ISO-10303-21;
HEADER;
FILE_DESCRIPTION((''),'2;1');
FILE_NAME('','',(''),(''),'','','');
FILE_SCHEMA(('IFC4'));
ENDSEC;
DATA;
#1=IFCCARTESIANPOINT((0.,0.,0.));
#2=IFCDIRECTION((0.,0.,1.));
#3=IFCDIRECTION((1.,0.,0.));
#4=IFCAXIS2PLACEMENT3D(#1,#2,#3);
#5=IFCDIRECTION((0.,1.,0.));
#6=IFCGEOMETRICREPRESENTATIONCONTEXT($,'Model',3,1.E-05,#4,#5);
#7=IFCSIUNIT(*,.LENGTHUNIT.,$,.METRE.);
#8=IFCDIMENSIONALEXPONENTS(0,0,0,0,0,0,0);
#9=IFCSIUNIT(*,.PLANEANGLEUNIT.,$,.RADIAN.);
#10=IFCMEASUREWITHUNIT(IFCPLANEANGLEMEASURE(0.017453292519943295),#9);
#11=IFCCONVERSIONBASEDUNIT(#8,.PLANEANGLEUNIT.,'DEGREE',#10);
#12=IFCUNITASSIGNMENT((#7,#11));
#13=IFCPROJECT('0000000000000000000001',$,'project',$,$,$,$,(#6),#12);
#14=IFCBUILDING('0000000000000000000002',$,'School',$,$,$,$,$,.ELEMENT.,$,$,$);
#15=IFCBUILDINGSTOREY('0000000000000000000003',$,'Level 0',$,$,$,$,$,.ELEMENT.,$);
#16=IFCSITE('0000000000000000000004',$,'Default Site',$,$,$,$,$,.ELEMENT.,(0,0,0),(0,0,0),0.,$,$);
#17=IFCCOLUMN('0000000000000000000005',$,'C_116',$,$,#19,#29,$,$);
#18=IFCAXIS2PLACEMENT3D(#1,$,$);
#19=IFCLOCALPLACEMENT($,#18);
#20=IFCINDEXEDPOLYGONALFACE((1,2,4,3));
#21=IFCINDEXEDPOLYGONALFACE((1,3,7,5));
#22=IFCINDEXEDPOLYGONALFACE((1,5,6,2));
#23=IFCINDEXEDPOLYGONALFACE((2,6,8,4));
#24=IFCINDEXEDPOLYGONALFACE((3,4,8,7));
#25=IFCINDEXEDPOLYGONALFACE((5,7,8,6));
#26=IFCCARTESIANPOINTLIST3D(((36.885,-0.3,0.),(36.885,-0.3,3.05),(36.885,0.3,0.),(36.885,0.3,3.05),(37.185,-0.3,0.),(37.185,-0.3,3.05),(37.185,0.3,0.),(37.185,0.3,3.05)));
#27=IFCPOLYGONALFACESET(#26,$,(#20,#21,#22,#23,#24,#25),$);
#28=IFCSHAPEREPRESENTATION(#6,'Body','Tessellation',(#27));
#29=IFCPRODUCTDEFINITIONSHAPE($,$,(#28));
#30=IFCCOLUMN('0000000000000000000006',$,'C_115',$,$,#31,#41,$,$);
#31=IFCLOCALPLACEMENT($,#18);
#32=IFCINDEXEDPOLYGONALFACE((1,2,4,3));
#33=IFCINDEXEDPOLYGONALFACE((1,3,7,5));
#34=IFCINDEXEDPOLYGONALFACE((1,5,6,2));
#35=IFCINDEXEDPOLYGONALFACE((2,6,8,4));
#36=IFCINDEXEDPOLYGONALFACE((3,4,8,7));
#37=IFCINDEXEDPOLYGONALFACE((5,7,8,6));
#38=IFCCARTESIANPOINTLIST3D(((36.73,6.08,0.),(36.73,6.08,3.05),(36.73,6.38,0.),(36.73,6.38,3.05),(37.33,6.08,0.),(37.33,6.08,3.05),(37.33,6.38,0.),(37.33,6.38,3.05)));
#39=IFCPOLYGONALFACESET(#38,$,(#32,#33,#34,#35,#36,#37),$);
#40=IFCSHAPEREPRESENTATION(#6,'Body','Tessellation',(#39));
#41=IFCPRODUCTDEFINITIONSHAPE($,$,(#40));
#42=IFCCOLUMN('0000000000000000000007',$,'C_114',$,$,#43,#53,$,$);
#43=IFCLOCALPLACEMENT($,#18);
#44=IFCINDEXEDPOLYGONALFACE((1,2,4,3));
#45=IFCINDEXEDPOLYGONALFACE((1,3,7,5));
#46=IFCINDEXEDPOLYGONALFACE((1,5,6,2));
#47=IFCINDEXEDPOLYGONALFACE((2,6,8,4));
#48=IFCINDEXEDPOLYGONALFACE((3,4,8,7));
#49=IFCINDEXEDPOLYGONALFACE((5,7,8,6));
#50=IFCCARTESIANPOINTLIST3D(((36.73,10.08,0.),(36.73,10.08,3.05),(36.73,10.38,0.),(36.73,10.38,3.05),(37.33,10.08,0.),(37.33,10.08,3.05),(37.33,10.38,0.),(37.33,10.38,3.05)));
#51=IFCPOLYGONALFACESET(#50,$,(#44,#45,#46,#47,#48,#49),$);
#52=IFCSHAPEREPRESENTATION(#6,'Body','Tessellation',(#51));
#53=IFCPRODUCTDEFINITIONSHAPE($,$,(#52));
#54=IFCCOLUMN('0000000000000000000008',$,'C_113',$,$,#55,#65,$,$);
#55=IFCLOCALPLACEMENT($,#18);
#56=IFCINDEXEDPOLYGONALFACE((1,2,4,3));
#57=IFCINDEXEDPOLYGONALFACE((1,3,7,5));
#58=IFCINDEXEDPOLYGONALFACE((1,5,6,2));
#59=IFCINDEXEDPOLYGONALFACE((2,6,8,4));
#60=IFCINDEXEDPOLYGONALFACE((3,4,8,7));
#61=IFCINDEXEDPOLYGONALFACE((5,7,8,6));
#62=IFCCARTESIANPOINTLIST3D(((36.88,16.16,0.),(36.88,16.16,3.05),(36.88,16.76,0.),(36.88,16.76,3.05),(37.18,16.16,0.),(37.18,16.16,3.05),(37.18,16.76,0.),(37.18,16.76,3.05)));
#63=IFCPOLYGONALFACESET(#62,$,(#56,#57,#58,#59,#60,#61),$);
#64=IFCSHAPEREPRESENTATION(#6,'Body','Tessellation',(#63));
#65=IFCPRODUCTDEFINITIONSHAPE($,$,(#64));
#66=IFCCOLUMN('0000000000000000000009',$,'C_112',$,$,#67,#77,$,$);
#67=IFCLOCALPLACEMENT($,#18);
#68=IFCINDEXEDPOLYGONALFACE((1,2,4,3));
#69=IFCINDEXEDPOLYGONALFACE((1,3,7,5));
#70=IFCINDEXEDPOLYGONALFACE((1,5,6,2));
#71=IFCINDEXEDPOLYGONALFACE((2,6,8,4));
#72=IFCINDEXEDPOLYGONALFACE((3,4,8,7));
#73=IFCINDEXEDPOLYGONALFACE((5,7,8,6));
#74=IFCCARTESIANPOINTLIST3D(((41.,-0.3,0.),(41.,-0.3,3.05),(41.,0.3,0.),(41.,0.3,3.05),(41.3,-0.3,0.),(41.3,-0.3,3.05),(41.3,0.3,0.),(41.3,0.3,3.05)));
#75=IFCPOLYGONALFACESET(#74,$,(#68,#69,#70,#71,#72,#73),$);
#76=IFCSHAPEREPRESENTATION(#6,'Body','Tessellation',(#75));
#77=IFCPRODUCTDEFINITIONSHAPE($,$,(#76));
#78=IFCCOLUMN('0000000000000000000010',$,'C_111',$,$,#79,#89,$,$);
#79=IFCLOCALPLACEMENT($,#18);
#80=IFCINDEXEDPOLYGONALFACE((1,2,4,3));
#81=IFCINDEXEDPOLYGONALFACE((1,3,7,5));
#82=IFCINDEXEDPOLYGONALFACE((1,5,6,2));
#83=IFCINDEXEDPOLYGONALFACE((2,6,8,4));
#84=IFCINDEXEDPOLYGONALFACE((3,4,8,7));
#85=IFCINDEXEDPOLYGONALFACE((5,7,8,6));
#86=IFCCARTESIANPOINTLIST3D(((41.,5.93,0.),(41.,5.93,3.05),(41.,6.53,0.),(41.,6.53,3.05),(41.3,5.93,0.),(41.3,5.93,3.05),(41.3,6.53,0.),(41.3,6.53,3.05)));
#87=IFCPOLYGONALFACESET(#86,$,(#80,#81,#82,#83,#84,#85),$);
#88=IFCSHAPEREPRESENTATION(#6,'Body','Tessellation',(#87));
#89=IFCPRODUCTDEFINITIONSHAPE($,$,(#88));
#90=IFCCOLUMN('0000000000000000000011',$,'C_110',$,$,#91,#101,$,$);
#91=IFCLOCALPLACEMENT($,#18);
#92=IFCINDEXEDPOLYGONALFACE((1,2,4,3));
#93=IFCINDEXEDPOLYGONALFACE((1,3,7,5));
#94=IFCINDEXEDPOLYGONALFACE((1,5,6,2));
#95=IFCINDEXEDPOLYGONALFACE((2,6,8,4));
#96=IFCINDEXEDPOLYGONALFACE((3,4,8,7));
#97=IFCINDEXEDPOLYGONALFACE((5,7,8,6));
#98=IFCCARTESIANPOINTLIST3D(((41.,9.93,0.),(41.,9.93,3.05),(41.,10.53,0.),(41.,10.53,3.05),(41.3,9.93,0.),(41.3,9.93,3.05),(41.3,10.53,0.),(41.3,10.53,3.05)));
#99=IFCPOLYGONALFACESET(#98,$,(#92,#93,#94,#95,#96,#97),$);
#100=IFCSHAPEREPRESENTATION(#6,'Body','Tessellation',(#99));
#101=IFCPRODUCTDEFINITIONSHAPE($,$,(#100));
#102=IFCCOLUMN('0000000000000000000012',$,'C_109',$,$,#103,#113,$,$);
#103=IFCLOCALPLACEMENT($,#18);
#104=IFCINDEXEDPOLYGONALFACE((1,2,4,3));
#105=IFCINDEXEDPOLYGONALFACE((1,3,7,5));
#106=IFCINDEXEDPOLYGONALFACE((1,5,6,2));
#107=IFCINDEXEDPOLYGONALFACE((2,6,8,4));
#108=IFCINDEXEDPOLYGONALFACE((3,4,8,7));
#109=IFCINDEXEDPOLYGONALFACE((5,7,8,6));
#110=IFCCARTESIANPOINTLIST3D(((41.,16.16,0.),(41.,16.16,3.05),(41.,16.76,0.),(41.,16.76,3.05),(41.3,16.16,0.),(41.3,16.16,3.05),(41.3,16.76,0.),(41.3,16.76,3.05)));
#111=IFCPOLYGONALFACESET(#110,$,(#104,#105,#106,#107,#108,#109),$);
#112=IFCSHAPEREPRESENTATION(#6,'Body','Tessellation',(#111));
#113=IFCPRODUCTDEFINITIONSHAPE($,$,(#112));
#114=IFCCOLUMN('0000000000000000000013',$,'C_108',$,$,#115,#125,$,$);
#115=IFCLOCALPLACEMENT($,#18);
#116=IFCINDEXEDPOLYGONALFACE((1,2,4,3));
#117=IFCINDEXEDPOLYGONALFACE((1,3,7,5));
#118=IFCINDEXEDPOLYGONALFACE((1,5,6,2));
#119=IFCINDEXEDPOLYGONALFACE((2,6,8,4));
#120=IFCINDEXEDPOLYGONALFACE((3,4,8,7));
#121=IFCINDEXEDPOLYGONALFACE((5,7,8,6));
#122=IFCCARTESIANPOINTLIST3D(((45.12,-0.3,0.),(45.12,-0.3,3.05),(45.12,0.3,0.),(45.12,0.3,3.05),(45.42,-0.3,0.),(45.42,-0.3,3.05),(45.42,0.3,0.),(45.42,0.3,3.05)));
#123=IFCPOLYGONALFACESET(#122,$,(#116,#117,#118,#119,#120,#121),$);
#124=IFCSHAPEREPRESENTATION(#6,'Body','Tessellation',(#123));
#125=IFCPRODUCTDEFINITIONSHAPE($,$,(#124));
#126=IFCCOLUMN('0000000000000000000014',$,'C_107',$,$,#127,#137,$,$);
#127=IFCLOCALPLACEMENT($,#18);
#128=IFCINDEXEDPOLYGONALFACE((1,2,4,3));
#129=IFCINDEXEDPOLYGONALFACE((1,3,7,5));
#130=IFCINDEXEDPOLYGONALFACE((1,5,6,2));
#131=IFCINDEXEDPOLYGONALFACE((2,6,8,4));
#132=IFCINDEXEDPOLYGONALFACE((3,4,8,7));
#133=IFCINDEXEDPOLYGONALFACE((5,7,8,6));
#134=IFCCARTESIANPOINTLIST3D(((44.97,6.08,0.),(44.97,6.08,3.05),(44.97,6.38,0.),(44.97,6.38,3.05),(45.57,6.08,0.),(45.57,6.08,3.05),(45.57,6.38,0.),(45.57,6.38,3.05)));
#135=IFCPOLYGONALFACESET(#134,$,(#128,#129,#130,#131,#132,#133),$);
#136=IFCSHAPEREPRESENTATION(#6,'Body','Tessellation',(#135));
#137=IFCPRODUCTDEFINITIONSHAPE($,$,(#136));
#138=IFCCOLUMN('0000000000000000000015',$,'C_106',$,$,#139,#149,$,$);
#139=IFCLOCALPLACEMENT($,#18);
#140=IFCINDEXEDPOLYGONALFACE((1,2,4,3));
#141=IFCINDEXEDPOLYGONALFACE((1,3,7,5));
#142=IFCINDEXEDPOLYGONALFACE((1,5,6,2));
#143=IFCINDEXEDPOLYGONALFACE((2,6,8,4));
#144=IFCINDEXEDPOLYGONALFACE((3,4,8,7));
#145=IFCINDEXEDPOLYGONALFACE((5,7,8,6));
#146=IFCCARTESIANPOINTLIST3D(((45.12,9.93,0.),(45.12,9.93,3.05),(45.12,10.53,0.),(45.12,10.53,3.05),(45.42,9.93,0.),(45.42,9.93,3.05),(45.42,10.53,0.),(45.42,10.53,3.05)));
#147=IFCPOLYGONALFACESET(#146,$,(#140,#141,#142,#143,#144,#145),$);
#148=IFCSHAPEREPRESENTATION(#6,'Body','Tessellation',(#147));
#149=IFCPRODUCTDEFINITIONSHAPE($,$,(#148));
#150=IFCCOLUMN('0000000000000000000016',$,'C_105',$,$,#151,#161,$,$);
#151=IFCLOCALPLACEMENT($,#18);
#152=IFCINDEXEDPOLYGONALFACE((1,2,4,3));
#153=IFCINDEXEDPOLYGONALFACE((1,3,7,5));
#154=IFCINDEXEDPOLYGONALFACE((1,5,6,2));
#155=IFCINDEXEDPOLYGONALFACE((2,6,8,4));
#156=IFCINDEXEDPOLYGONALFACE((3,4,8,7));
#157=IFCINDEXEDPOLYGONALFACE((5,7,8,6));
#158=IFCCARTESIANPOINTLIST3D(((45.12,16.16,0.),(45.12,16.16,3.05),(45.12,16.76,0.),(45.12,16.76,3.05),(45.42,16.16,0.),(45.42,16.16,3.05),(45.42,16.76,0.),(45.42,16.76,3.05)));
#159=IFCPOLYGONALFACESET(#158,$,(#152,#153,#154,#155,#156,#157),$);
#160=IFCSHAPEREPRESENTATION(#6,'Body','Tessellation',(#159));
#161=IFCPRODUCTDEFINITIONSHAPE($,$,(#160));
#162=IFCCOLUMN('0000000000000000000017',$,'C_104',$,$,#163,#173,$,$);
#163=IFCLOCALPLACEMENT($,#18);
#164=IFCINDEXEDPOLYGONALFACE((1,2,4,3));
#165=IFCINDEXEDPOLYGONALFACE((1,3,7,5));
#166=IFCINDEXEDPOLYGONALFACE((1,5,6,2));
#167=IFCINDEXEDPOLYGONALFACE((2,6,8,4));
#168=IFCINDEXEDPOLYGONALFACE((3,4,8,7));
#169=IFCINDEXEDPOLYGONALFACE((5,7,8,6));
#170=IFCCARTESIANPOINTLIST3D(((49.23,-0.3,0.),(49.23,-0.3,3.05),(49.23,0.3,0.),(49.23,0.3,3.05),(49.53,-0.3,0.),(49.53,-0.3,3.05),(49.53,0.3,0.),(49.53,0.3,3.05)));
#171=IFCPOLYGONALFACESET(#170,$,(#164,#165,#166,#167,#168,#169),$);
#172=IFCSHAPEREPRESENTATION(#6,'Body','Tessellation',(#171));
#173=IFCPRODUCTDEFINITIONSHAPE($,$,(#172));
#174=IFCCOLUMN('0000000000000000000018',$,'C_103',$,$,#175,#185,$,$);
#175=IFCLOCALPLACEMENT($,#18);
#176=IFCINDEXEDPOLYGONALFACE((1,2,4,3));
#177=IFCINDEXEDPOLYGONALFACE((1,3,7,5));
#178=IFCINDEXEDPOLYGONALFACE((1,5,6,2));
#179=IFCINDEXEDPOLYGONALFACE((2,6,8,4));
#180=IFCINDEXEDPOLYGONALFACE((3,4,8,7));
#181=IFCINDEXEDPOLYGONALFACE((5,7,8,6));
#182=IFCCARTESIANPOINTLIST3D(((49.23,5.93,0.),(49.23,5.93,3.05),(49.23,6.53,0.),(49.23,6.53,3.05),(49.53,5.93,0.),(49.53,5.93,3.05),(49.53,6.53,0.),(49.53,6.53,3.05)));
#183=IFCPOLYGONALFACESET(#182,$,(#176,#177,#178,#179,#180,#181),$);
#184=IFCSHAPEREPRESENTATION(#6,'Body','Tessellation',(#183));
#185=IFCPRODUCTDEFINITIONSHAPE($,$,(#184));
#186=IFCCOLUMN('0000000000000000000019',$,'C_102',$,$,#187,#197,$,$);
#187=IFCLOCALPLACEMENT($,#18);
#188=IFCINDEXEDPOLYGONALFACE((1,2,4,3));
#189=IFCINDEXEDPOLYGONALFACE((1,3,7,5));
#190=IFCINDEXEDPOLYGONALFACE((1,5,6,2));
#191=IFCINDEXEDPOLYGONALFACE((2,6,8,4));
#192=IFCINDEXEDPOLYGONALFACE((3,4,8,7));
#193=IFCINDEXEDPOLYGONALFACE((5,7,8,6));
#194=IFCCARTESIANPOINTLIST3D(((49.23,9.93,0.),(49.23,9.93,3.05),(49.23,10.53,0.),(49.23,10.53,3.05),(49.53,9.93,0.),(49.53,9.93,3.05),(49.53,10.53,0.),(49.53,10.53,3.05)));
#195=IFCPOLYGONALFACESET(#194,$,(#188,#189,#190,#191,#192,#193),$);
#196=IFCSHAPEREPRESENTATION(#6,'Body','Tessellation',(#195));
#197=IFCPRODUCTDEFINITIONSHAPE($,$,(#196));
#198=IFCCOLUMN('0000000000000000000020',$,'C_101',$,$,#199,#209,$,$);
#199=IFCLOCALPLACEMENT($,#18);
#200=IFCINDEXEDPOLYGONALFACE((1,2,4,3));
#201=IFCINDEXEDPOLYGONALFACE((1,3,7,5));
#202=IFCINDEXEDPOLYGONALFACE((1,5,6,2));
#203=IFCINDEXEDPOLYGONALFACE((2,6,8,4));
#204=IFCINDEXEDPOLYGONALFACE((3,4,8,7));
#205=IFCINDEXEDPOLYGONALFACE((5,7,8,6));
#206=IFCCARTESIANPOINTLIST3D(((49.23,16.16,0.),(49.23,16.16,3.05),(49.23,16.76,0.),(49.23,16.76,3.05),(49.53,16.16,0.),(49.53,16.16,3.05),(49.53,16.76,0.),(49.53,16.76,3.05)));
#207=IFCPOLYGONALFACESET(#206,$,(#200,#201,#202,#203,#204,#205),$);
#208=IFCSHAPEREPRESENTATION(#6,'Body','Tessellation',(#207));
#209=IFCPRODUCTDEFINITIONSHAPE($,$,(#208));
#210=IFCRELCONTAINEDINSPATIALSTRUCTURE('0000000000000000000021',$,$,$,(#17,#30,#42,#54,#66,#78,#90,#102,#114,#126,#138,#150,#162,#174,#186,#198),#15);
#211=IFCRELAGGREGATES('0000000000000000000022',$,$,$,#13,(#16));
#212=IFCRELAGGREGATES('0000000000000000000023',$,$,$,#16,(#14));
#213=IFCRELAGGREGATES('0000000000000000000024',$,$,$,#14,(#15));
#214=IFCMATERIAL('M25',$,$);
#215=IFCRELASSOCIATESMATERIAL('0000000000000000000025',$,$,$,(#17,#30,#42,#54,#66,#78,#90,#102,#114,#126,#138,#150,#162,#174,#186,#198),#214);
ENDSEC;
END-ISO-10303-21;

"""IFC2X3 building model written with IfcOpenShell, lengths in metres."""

from ifc_helpers import new_model, entity, si_unit, converted_unit, direction, frame, frame_2d, origin_with_axes, place, context, project, spatial, rectangle, extrude, material, element, save


model = new_model("IFC2X3")

# Units and contexts
model_context = context("Model", 3, precision=1e-05, world=origin_with_axes(), true_north=direction((0.0, 1.0, 0.0)))
ifc_project = project(units=[si_unit("LENGTHUNIT", "METRE"), converted_unit("PLANEANGLEUNIT", "DEGREE", entity("IfcPlaneAngleMeasure", 0.017453292519943295), si_unit("PLANEANGLEUNIT", "RADIAN"), dimensions=[0, 0, 0, 0, 0, 0, 0])], contexts=[model_context])

# Site, building, storey
site = spatial("IfcSite", under=ifc_project, Name="Default Site", CompositionType="ELEMENT", RefLatitude=(0, 0, 0), RefLongitude=(0, 0, 0), RefElevation=0.0)
building = spatial("IfcBuilding", under=site, Name="School", CompositionType="ELEMENT")
storey = spatial("IfcBuildingStorey", under=building, Name="Level 0", CompositionType="ELEMENT")

# Columns
ifc_material = material(Name="M25")
placement = place(None, origin_with_axes())
element("IfcColumn", 1, at=placement, inside=storey, material=ifc_material, Name="C_116", context=model_context, shape_type="SweptSolid", body=[
    extrude(rectangle(XDim=0.3, YDim=0.6, at=frame_2d((0.0, 0.0), x_axis=(1.0, 0.0, 0.0))), frame((37.035, 0.0, 0.0), z_axis=(0.0, 0.0, 1.0), x_axis=(1.0, 0.0, 0.0)), (0.0, 0.0, 1.0), 3.05),
])
element("IfcColumn", 2, at=placement, inside=storey, material=ifc_material, Name="C_115", context=model_context, shape_type="SweptSolid", body=[
    extrude(rectangle(XDim=0.6, YDim=0.3, at=frame_2d((0.0, 0.0), x_axis=(1.0, 0.0, 0.0))), frame((37.03, 6.23, 0.0), z_axis=(0.0, 0.0, 1.0), x_axis=(1.0, 0.0, 0.0)), (0.0, 0.0, 1.0), 3.05),
])
element("IfcColumn", 3, at=placement, inside=storey, material=ifc_material, Name="C_114", context=model_context, shape_type="SweptSolid", body=[
    extrude(rectangle(XDim=0.6, YDim=0.3, at=frame_2d((0.0, 0.0), x_axis=(1.0, 0.0, 0.0))), frame((37.03, 10.23, 0.0), z_axis=(0.0, 0.0, 1.0), x_axis=(1.0, 0.0, 0.0)), (0.0, 0.0, 1.0), 3.05),
])
element("IfcColumn", 4, at=placement, inside=storey, material=ifc_material, Name="C_113", context=model_context, shape_type="SweptSolid", body=[
    extrude(rectangle(XDim=0.3, YDim=0.6, at=frame_2d((0.0, 0.0), x_axis=(1.0, 0.0, 0.0))), frame((37.03, 16.46, 0.0), z_axis=(0.0, 0.0, 1.0), x_axis=(1.0, 0.0, 0.0)), (0.0, 0.0, 1.0), 3.05),
])
element("IfcColumn", 5, at=placement, inside=storey, material=ifc_material, Name="C_112", context=model_context, shape_type="SweptSolid", body=[
    extrude(rectangle(XDim=0.3, YDim=0.6, at=frame_2d((0.0, 0.0), x_axis=(1.0, 0.0, 0.0))), frame((41.15, 0.0, 0.0), z_axis=(0.0, 0.0, 1.0), x_axis=(1.0, 0.0, 0.0)), (0.0, 0.0, 1.0), 3.05),
])
element("IfcColumn", 6, at=placement, inside=storey, material=ifc_material, Name="C_111", context=model_context, shape_type="SweptSolid", body=[
    extrude(rectangle(XDim=0.3, YDim=0.6, at=frame_2d((0.0, 0.0), x_axis=(1.0, 0.0, 0.0))), frame((41.15, 6.23, 0.0), z_axis=(0.0, 0.0, 1.0), x_axis=(1.0, 0.0, 0.0)), (0.0, 0.0, 1.0), 3.05),
])
element("IfcColumn", 7, at=placement, inside=storey, material=ifc_material, Name="C_110", context=model_context, shape_type="SweptSolid", body=[
    extrude(rectangle(XDim=0.3, YDim=0.6, at=frame_2d((0.0, 0.0), x_axis=(1.0, 0.0, 0.0))), frame((41.15, 10.23, 0.0), z_axis=(0.0, 0.0, 1.0), x_axis=(1.0, 0.0, 0.0)), (0.0, 0.0, 1.0), 3.05),
])
element("IfcColumn", 8, at=placement, inside=storey, material=ifc_material, Name="C_109", context=model_context, shape_type="SweptSolid", body=[
    extrude(rectangle(XDim=0.3, YDim=0.6, at=frame_2d((0.0, 0.0), x_axis=(1.0, 0.0, 0.0))), frame((41.15, 16.46, 0.0), z_axis=(0.0, 0.0, 1.0), x_axis=(1.0, 0.0, 0.0)), (0.0, 0.0, 1.0), 3.05),
])
element("IfcColumn", 9, at=placement, inside=storey, material=ifc_material, Name="C_108", context=model_context, shape_type="SweptSolid", body=[
    extrude(rectangle(XDim=0.3, YDim=0.6, at=frame_2d((0.0, 0.0), x_axis=(1.0, 0.0, 0.0))), frame((45.27, 0.0, 0.0), z_axis=(0.0, 0.0, 1.0), x_axis=(1.0, 0.0, 0.0)), (0.0, 0.0, 1.0), 3.05),
])
element("IfcColumn", 10, at=placement, inside=storey, material=ifc_material, Name="C_107", context=model_context, shape_type="SweptSolid", body=[
    extrude(rectangle(XDim=0.6, YDim=0.3, at=frame_2d((0.0, 0.0), x_axis=(1.0, 0.0, 0.0))), frame((45.27, 6.23, 0.0), z_axis=(0.0, 0.0, 1.0), x_axis=(1.0, 0.0, 0.0)), (0.0, 0.0, 1.0), 3.05),
])
element("IfcColumn", 11, at=placement, inside=storey, material=ifc_material, Name="C_106", context=model_context, shape_type="SweptSolid", body=[
    extrude(rectangle(XDim=0.3, YDim=0.6, at=frame_2d((0.0, 0.0), x_axis=(1.0, 0.0, 0.0))), frame((45.27, 10.23, 0.0), z_axis=(0.0, 0.0, 1.0), x_axis=(1.0, 0.0, 0.0)), (0.0, 0.0, 1.0), 3.05),
])
element("IfcColumn", 12, at=placement, inside=storey, material=ifc_material, Name="C_105", context=model_context, shape_type="SweptSolid", body=[
    extrude(rectangle(XDim=0.3, YDim=0.6, at=frame_2d((0.0, 0.0), x_axis=(1.0, 0.0, 0.0))), frame((45.27, 16.46, 0.0), z_axis=(0.0, 0.0, 1.0), x_axis=(1.0, 0.0, 0.0)), (0.0, 0.0, 1.0), 3.05),
])
element("IfcColumn", 13, at=placement, inside=storey, material=ifc_material, Name="C_104", context=model_context, shape_type="SweptSolid", body=[
    extrude(rectangle(XDim=0.3, YDim=0.6, at=frame_2d((0.0, 0.0), x_axis=(1.0, 0.0, 0.0))), frame((49.38, 0.0, 0.0), z_axis=(0.0, 0.0, 1.0), x_axis=(1.0, 0.0, 0.0)), (0.0, 0.0, 1.0), 3.05),
])
element("IfcColumn", 14, at=placement, inside=storey, material=ifc_material, Name="C_103", context=model_context, shape_type="SweptSolid", body=[
    extrude(rectangle(XDim=0.3, YDim=0.6, at=frame_2d((0.0, 0.0), x_axis=(1.0, 0.0, 0.0))), frame((49.38, 6.23, 0.0), z_axis=(0.0, 0.0, 1.0), x_axis=(1.0, 0.0, 0.0)), (0.0, 0.0, 1.0), 3.05),
])
element("IfcColumn", 15, at=placement, inside=storey, material=ifc_material, Name="C_102", context=model_context, shape_type="SweptSolid", body=[
    extrude(rectangle(XDim=0.3, YDim=0.6, at=frame_2d((0.0, 0.0), x_axis=(1.0, 0.0, 0.0))), frame((49.38, 10.23, 0.0), z_axis=(0.0, 0.0, 1.0), x_axis=(1.0, 0.0, 0.0)), (0.0, 0.0, 1.0), 3.05),
])
element("IfcColumn", 16, at=placement, inside=storey, material=ifc_material, Name="C_101", context=model_context, shape_type="SweptSolid", body=[
    extrude(rectangle(XDim=0.3, YDim=0.6, at=frame_2d((0.0, 0.0), x_axis=(1.0, 0.0, 0.0))), frame((49.38, 16.46, 0.0), z_axis=(0.0, 0.0, 1.0), x_axis=(1.0, 0.0, 0.0)), (0.0, 0.0, 1.0), 3.05),
])

save(model, "model.ifc")
